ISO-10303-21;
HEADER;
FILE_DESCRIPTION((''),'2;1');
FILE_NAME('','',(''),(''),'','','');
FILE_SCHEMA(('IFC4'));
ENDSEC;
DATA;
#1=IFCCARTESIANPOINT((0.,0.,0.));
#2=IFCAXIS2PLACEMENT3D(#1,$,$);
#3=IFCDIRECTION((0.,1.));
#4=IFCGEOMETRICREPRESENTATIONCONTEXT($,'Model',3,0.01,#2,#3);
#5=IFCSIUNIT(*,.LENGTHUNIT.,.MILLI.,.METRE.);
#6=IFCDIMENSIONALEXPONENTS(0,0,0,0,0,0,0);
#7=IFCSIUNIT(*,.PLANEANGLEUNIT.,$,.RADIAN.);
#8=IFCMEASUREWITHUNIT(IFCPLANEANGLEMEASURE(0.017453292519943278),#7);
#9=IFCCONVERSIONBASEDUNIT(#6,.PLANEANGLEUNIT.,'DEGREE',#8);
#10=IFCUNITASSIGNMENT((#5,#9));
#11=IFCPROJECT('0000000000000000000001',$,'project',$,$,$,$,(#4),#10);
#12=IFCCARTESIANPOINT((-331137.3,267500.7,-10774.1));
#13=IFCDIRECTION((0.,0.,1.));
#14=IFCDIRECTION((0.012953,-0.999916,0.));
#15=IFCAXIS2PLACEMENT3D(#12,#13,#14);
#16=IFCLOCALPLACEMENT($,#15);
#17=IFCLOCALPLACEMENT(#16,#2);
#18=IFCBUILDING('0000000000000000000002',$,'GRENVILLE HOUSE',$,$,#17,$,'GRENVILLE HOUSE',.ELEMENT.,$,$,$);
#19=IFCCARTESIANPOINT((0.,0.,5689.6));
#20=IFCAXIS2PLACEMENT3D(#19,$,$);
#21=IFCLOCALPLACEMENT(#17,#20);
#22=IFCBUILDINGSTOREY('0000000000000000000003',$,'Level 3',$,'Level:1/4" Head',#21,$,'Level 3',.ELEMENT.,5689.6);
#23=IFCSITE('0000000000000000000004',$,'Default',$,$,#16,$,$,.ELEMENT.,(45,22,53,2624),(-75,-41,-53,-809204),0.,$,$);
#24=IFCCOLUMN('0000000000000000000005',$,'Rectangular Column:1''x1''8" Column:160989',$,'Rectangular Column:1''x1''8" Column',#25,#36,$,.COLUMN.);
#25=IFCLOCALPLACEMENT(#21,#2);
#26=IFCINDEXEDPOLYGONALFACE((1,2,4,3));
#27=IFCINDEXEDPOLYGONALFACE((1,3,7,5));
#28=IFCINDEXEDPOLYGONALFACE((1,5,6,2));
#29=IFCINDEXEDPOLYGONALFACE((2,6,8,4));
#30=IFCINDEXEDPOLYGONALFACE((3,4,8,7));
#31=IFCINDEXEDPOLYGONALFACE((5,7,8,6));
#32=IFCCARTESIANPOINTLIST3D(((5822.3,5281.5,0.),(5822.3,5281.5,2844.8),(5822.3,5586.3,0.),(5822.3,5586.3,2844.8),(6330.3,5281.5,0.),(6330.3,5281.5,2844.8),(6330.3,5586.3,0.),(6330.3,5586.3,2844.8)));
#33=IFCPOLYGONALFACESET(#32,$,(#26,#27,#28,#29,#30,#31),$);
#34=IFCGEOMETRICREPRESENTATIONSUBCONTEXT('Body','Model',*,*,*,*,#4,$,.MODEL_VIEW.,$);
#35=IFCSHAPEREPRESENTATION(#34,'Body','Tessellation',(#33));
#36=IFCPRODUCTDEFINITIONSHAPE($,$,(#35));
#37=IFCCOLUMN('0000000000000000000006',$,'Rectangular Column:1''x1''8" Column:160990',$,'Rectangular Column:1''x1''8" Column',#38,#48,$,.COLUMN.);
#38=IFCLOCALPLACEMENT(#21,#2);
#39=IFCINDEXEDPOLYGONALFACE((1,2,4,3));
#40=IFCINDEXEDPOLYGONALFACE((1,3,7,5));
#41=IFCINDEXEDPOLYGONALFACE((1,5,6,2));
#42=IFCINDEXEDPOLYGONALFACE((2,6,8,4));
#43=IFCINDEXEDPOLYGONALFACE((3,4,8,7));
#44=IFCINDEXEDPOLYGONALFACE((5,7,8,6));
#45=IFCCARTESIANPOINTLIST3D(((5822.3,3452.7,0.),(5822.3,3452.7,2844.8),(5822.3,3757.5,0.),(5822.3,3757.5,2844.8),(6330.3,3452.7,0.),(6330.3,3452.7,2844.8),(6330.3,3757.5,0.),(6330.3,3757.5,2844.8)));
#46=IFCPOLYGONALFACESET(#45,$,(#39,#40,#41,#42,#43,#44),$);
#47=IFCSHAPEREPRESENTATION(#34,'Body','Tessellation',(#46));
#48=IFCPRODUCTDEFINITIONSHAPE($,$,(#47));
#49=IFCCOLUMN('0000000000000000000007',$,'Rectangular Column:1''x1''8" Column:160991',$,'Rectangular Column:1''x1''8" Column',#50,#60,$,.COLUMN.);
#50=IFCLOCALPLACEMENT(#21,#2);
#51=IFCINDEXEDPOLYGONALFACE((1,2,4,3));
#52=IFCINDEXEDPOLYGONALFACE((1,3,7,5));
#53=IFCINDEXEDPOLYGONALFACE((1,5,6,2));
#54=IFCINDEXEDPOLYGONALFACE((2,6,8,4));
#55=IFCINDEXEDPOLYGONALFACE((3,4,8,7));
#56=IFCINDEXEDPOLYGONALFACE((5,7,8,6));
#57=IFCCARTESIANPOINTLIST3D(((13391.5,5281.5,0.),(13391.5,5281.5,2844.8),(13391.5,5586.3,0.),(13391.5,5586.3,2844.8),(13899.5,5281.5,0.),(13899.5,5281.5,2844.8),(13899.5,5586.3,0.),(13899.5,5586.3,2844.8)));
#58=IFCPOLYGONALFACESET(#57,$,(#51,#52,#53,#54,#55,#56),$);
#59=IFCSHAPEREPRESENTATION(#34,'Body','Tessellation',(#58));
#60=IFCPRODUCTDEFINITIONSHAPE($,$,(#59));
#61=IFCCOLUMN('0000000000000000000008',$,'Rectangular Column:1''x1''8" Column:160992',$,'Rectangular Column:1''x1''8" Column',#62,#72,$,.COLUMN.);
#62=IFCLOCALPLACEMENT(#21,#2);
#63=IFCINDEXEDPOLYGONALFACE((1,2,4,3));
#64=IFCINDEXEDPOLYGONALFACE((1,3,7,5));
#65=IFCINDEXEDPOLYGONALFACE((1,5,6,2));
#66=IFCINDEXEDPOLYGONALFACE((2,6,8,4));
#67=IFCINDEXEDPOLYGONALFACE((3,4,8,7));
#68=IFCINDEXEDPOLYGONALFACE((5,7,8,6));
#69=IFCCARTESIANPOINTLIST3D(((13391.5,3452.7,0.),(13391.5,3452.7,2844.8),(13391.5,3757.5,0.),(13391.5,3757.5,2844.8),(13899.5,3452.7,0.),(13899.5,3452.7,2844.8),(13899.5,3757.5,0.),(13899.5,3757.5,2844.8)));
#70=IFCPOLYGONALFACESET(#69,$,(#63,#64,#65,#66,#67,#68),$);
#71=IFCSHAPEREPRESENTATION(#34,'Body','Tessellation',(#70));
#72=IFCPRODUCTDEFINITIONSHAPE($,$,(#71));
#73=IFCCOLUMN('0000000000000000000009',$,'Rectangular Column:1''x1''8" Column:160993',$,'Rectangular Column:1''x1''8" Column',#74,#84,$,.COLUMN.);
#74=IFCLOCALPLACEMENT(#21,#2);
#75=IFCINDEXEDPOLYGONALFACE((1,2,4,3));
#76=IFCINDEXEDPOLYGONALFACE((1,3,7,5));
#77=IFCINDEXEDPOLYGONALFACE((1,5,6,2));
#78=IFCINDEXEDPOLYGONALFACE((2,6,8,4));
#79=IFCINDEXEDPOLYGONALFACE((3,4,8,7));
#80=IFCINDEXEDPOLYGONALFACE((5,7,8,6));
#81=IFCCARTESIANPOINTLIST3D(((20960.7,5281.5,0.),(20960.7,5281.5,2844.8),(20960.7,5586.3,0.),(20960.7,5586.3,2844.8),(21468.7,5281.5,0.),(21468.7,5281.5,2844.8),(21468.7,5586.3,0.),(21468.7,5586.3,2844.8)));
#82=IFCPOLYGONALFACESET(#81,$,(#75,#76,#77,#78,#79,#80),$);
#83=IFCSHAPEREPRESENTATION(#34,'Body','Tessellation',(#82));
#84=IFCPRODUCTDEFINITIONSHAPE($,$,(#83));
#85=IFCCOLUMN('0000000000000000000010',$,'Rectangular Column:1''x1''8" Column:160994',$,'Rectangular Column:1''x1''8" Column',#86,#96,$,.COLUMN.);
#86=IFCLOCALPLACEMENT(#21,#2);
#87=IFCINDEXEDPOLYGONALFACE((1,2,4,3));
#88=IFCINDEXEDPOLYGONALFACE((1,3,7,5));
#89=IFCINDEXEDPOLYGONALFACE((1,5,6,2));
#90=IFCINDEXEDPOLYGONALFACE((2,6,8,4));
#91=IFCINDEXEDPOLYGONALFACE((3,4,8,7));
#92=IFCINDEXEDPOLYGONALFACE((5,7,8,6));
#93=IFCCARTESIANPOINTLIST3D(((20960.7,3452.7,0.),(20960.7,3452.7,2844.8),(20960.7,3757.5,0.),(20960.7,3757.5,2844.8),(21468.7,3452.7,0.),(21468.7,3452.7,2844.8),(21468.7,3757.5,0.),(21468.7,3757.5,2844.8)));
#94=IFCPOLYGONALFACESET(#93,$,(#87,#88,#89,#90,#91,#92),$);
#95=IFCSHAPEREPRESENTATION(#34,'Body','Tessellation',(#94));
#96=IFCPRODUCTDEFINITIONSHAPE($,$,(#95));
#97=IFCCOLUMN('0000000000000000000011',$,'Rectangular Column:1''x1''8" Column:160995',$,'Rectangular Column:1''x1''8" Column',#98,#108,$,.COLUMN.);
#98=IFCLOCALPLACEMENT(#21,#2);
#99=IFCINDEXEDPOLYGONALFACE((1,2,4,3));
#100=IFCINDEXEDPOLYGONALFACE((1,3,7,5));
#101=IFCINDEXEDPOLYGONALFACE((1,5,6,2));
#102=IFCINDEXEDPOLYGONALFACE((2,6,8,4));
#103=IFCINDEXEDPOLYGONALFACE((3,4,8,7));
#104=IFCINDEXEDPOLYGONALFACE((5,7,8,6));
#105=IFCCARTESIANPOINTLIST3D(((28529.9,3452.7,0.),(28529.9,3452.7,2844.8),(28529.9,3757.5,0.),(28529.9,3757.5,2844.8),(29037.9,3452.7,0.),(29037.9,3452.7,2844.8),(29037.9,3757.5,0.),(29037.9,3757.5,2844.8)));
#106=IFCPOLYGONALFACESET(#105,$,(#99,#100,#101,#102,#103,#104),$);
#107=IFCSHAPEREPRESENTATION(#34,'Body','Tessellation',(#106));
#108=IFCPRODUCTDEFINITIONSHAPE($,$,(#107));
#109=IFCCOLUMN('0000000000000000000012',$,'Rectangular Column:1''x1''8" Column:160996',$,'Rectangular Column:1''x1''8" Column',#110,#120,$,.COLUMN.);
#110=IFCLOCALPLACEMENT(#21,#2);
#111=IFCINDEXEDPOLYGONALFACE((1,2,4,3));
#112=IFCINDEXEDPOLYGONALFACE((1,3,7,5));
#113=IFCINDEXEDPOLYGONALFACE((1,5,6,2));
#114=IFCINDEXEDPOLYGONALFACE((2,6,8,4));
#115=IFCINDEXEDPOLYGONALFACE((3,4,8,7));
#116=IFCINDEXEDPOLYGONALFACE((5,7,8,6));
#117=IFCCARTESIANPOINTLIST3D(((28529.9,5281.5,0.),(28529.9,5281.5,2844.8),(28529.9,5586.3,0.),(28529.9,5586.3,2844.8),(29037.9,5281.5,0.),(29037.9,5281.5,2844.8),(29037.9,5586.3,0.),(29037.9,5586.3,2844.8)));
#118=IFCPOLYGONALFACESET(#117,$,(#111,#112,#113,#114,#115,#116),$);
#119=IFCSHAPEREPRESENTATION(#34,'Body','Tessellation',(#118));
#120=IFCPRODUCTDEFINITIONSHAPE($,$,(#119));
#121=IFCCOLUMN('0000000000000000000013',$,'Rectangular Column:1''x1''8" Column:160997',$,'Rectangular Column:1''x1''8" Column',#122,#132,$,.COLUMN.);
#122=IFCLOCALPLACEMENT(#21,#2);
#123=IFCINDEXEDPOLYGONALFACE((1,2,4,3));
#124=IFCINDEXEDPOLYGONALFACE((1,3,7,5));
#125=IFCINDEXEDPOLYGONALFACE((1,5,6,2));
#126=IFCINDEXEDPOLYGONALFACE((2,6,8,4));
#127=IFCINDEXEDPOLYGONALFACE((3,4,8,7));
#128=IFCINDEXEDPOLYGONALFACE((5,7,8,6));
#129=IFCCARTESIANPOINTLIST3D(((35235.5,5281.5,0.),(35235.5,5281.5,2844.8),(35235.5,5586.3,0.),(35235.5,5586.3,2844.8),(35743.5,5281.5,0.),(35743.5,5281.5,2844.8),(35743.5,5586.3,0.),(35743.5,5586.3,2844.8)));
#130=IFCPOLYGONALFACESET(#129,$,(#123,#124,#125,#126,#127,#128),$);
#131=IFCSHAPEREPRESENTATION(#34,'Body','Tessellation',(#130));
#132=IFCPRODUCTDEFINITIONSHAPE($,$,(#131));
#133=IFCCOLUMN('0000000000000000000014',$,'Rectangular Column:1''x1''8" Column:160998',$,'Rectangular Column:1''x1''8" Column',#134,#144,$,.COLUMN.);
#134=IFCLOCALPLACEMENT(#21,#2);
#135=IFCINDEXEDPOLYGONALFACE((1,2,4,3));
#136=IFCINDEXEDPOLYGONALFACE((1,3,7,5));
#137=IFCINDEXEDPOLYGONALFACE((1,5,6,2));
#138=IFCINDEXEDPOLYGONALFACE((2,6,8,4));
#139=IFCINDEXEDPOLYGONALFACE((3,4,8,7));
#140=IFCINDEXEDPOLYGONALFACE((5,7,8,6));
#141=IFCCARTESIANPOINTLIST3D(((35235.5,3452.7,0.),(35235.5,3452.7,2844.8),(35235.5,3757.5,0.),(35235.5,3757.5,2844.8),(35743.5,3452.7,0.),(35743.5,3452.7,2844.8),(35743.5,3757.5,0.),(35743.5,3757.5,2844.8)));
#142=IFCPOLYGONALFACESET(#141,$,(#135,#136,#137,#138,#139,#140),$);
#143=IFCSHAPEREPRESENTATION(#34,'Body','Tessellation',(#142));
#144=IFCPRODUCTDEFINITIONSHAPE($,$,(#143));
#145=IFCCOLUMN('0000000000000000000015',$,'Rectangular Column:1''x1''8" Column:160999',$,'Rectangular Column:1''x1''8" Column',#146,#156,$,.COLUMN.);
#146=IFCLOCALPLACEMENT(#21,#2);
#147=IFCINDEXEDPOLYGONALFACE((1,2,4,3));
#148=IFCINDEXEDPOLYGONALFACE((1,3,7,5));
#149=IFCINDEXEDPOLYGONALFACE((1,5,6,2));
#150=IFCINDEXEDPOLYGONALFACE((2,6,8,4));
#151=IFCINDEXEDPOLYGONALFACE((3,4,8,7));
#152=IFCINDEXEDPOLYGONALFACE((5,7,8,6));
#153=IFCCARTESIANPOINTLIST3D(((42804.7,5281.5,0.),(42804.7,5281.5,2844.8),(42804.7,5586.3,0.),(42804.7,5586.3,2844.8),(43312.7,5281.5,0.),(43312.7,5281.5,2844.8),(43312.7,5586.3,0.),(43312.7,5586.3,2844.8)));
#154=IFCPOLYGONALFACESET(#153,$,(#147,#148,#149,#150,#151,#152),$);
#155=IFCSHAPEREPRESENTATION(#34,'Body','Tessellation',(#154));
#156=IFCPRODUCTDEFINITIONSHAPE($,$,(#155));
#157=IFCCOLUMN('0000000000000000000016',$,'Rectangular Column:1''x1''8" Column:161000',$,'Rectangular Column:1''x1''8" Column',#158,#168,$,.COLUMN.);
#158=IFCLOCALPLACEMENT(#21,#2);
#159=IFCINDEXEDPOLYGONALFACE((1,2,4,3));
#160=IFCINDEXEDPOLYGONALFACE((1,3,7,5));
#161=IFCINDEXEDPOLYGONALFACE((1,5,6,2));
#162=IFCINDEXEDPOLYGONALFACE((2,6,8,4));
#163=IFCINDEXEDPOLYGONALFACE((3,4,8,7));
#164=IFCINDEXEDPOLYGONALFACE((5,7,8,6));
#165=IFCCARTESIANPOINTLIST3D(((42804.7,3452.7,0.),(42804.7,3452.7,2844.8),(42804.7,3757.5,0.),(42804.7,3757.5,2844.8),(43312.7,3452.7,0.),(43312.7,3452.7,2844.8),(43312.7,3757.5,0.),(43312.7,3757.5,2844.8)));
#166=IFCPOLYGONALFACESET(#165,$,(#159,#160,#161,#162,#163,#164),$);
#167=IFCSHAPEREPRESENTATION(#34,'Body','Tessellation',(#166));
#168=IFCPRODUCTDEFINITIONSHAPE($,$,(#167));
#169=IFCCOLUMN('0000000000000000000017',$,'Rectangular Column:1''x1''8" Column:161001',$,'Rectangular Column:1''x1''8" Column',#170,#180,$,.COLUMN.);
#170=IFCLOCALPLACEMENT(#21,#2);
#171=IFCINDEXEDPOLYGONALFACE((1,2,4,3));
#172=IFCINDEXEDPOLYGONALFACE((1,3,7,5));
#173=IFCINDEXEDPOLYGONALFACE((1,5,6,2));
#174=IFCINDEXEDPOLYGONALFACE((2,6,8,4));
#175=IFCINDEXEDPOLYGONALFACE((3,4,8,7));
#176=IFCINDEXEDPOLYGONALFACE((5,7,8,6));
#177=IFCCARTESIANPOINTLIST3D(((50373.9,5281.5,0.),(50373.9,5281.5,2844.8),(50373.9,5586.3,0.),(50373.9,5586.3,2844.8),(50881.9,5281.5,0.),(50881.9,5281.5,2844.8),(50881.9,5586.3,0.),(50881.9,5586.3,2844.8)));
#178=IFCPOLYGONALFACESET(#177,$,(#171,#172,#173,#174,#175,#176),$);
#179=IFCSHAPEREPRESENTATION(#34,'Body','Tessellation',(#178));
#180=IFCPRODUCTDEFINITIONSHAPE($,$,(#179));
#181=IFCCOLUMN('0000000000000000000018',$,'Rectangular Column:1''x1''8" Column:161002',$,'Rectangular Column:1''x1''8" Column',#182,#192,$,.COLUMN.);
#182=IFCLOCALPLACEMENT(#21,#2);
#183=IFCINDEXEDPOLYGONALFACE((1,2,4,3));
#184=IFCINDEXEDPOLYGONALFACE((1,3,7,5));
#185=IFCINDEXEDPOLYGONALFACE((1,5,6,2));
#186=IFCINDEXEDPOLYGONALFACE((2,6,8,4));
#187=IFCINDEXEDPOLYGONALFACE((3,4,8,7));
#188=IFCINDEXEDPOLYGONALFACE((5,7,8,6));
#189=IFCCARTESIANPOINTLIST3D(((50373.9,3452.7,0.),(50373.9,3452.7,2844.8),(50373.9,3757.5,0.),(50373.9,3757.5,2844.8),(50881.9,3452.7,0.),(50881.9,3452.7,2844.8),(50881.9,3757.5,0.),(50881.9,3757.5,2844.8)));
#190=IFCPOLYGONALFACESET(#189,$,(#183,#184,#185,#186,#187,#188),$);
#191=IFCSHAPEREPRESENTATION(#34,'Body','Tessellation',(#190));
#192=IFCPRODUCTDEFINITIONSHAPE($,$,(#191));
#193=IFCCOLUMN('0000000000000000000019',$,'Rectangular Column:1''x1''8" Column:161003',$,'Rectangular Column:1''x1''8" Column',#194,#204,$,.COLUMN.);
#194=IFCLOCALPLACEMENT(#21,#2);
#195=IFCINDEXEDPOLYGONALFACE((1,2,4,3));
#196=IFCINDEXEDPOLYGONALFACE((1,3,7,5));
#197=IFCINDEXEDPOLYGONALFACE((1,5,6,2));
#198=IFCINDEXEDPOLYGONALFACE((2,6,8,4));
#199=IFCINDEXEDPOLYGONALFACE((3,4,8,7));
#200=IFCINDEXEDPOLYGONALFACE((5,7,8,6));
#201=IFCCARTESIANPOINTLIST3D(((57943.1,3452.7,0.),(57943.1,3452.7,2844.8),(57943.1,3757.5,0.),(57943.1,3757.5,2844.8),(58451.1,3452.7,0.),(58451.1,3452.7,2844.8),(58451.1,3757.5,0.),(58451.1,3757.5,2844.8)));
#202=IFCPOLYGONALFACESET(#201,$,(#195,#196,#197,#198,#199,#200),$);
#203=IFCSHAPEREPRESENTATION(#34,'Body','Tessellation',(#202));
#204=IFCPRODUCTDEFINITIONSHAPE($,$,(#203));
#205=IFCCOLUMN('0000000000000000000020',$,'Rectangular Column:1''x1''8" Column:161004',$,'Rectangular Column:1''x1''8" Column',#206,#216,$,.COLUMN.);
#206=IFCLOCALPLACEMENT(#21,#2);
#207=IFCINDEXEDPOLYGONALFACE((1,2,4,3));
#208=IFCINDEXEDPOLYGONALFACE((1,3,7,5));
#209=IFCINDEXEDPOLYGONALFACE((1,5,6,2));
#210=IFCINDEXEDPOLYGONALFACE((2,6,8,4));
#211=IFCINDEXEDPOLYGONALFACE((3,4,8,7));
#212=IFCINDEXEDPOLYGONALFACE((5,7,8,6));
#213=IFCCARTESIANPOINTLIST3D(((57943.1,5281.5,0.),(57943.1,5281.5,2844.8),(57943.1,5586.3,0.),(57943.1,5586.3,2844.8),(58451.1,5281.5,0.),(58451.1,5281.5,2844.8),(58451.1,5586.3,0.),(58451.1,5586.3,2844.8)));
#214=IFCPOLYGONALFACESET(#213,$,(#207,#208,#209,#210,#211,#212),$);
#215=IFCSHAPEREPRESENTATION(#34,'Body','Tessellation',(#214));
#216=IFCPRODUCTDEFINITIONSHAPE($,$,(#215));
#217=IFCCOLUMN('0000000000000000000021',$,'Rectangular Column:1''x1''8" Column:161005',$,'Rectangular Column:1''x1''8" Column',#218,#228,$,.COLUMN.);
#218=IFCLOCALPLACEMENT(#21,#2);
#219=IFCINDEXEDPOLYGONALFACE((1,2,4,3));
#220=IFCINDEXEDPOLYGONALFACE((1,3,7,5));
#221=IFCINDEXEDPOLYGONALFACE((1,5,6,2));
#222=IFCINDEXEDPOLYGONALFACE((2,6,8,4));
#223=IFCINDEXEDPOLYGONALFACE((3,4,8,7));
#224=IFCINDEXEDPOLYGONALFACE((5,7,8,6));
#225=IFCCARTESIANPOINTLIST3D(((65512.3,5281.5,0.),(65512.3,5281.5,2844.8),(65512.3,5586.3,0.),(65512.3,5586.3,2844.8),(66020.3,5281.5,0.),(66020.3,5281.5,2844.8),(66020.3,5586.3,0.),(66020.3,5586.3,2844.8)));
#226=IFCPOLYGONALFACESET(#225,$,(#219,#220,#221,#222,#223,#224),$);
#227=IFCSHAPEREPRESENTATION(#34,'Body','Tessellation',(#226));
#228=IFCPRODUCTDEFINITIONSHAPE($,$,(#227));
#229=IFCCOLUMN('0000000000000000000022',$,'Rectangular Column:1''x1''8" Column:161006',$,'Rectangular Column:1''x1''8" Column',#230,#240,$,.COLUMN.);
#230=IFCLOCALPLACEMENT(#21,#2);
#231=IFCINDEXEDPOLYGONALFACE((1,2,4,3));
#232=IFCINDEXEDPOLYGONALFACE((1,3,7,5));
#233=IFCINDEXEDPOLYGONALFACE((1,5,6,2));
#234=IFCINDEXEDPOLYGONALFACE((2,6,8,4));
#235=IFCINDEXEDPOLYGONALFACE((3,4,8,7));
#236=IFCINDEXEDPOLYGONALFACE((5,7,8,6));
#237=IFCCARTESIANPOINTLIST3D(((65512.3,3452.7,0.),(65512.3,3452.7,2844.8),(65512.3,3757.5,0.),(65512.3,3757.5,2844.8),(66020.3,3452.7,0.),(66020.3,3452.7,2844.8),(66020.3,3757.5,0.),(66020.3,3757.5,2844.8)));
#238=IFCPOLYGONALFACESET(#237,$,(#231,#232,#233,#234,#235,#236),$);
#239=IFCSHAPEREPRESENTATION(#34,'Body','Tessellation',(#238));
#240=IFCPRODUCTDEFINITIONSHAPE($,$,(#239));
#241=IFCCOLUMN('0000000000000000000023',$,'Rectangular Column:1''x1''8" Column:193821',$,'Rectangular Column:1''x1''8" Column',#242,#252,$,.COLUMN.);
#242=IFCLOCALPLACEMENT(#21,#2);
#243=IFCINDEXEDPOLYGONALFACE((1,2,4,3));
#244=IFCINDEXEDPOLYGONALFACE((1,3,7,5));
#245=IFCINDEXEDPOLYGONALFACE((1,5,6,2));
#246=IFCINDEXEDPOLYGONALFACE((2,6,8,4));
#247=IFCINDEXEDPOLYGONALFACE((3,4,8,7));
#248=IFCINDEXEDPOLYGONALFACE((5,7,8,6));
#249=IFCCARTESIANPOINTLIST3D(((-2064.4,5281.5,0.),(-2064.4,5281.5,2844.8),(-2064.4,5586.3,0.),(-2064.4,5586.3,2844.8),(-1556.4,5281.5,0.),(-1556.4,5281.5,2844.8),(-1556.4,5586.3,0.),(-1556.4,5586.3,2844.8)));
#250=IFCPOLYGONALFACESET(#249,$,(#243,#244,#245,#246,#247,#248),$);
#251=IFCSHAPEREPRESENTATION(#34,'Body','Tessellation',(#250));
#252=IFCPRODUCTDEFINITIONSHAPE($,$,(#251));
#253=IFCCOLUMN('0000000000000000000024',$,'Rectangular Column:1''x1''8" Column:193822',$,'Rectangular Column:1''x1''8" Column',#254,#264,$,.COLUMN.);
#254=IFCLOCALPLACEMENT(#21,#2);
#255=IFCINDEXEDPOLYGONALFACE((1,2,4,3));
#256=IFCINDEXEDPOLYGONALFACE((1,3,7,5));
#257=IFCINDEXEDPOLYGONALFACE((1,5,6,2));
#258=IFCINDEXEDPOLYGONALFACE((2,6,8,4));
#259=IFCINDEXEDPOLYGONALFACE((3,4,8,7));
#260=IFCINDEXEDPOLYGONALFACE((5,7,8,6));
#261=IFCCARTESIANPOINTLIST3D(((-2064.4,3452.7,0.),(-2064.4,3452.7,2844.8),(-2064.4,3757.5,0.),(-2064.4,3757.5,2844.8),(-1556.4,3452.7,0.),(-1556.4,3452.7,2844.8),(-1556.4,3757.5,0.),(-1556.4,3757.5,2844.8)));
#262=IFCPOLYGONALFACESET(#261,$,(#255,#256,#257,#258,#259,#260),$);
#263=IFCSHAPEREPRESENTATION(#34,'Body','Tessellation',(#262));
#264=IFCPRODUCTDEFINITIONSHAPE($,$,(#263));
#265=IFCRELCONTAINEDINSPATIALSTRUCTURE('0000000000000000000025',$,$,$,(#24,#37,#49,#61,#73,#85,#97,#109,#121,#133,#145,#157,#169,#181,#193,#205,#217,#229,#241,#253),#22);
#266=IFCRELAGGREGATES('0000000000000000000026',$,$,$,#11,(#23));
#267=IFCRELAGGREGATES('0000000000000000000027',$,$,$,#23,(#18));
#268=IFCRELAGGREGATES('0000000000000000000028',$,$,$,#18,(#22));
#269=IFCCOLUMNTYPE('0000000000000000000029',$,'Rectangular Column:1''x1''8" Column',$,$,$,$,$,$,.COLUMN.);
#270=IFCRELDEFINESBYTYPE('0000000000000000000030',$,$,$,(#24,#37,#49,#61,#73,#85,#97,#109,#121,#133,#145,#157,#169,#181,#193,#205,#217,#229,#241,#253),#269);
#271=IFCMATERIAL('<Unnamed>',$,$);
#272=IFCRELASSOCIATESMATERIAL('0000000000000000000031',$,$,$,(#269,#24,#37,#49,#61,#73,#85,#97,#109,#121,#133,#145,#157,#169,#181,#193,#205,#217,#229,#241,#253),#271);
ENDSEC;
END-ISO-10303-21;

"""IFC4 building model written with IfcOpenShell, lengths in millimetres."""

from ifc_helpers import new_model, entity, si_unit, converted_unit, direction, frame, origin, place, context, subcontext, project, spatial, indexed_curve, outline, extrude, source, transform, mapped, material, type_object, type_shapes, element, save


model = new_model("IFC4")

# Units and contexts
model_context = context("Model", 3, precision=0.01, world=origin(), true_north=direction((0.0, 1.0)))
body_context = subcontext(model_context, "Body", "Model", "MODEL_VIEW")
ifc_project = project(units=[si_unit("LENGTHUNIT", "METRE", prefix="MILLI"), converted_unit("PLANEANGLEUNIT", "DEGREE", entity("IfcPlaneAngleMeasure", 0.017453292519943278), si_unit("PLANEANGLEUNIT", "RADIAN"), dimensions=[0, 0, 0, 0, 0, 0, 0])], contexts=[model_context])

# Site, building, storey
site_placement = place(None, frame((-331137.3, 267500.7, -10774.1), z_axis=(0.0, 0.0, 1.0), x_axis=(0.012953, -0.999916, 0.0)))
site = spatial("IfcSite", under=ifc_project, at=site_placement, Name="Default", CompositionType="ELEMENT", RefLatitude=(45, 22, 53, 2624), RefLongitude=(-75, -41, -53, -809204), RefElevation=0.0)
building_placement = place(site_placement, origin())
building = spatial("IfcBuilding", under=site, at=building_placement, Name="GRENVILLE HOUSE", LongName="GRENVILLE HOUSE", CompositionType="ELEMENT")
storey_placement = place(building_placement, frame((0.0, 0.0, 5689.6)))
storey = spatial("IfcBuildingStorey", under=building, at=storey_placement, Name="Level 3", ObjectType="Level:1/4\" Head", LongName="Level 3", CompositionType="ELEMENT", Elevation=5689.6)

# Columns
ifc_material_1 = material(Name="<Unnamed>")
column_type = type_object("IfcColumnType", Name="Rectangular Column:1'x1'8\" Column", PredefinedType="COLUMN", material=ifc_material_1)
shared_shape_1 = source(origin(), body_context, "Body", "SweptSolid", [
    extrude(outline(indexed_curve([(-254.0, -152.4), (254.0, -152.4), (254.0, 152.4), (-254.0, 152.4), (-254.0, -152.4)], self_intersect=False)), frame((0.0, 0.0, 5689.6), z_axis=(0.0, 0.0, 1.0), x_axis=(-1.0, 0.0, 0.0)), (0.0, 0.0, 1.0), 2844.8),
])
type_shapes(column_type, [shared_shape_1])
for number, where, name in (
    (1, (6076.3, 5433.9, -5689.6), "Rectangular Column:1'x1'8\" Column:160989"),
    (2, (6076.3, 3605.1, -5689.6), "Rectangular Column:1'x1'8\" Column:160990"),
    (3, (13645.5, 5433.9, -5689.6), "Rectangular Column:1'x1'8\" Column:160991"),
    (4, (13645.5, 3605.1, -5689.6), "Rectangular Column:1'x1'8\" Column:160992"),
    (5, (21214.7, 5433.9, -5689.6), "Rectangular Column:1'x1'8\" Column:160993"),
    (6, (21214.7, 3605.1, -5689.6), "Rectangular Column:1'x1'8\" Column:160994"),
    (7, (28783.9, 3605.1, -5689.6), "Rectangular Column:1'x1'8\" Column:160995"),
    (8, (28783.9, 5433.9, -5689.6), "Rectangular Column:1'x1'8\" Column:160996"),
    (9, (35489.5, 5433.9, -5689.6), "Rectangular Column:1'x1'8\" Column:160997"),
    (10, (35489.5, 3605.1, -5689.6), "Rectangular Column:1'x1'8\" Column:160998"),
    (11, (43058.7, 5433.9, -5689.6), "Rectangular Column:1'x1'8\" Column:160999"),
    (12, (43058.7, 3605.1, -5689.6), "Rectangular Column:1'x1'8\" Column:161000"),
    (13, (50627.9, 5433.9, -5689.6), "Rectangular Column:1'x1'8\" Column:161001"),
    (14, (50627.9, 3605.1, -5689.6), "Rectangular Column:1'x1'8\" Column:161002"),
    (15, (58197.1, 3605.1, -5689.6), "Rectangular Column:1'x1'8\" Column:161003"),
    (16, (58197.1, 5433.9, -5689.6), "Rectangular Column:1'x1'8\" Column:161004"),
    (17, (65766.3, 5433.9, -5689.6), "Rectangular Column:1'x1'8\" Column:161005"),
    (18, (65766.3, 3605.1, -5689.6), "Rectangular Column:1'x1'8\" Column:161006"),
    (19, (-1810.4, 5433.9, -5689.6), "Rectangular Column:1'x1'8\" Column:193821"),
    (20, (-1810.4, 3605.1, -5689.6), "Rectangular Column:1'x1'8\" Column:193822"),
):
    element("IfcColumn", number, at=place(storey_placement, frame(where)), inside=storey, type_object=column_type, material=ifc_material_1, Name=name, ObjectType="Rectangular Column:1'x1'8\" Column", PredefinedType="COLUMN", context=body_context, shape_type="MappedRepresentation", body=[
        mapped(shared_shape_1, transform((0.0, 0.0, 0.0), scale=1.0)),
    ])

save(model, "model.ifc")
